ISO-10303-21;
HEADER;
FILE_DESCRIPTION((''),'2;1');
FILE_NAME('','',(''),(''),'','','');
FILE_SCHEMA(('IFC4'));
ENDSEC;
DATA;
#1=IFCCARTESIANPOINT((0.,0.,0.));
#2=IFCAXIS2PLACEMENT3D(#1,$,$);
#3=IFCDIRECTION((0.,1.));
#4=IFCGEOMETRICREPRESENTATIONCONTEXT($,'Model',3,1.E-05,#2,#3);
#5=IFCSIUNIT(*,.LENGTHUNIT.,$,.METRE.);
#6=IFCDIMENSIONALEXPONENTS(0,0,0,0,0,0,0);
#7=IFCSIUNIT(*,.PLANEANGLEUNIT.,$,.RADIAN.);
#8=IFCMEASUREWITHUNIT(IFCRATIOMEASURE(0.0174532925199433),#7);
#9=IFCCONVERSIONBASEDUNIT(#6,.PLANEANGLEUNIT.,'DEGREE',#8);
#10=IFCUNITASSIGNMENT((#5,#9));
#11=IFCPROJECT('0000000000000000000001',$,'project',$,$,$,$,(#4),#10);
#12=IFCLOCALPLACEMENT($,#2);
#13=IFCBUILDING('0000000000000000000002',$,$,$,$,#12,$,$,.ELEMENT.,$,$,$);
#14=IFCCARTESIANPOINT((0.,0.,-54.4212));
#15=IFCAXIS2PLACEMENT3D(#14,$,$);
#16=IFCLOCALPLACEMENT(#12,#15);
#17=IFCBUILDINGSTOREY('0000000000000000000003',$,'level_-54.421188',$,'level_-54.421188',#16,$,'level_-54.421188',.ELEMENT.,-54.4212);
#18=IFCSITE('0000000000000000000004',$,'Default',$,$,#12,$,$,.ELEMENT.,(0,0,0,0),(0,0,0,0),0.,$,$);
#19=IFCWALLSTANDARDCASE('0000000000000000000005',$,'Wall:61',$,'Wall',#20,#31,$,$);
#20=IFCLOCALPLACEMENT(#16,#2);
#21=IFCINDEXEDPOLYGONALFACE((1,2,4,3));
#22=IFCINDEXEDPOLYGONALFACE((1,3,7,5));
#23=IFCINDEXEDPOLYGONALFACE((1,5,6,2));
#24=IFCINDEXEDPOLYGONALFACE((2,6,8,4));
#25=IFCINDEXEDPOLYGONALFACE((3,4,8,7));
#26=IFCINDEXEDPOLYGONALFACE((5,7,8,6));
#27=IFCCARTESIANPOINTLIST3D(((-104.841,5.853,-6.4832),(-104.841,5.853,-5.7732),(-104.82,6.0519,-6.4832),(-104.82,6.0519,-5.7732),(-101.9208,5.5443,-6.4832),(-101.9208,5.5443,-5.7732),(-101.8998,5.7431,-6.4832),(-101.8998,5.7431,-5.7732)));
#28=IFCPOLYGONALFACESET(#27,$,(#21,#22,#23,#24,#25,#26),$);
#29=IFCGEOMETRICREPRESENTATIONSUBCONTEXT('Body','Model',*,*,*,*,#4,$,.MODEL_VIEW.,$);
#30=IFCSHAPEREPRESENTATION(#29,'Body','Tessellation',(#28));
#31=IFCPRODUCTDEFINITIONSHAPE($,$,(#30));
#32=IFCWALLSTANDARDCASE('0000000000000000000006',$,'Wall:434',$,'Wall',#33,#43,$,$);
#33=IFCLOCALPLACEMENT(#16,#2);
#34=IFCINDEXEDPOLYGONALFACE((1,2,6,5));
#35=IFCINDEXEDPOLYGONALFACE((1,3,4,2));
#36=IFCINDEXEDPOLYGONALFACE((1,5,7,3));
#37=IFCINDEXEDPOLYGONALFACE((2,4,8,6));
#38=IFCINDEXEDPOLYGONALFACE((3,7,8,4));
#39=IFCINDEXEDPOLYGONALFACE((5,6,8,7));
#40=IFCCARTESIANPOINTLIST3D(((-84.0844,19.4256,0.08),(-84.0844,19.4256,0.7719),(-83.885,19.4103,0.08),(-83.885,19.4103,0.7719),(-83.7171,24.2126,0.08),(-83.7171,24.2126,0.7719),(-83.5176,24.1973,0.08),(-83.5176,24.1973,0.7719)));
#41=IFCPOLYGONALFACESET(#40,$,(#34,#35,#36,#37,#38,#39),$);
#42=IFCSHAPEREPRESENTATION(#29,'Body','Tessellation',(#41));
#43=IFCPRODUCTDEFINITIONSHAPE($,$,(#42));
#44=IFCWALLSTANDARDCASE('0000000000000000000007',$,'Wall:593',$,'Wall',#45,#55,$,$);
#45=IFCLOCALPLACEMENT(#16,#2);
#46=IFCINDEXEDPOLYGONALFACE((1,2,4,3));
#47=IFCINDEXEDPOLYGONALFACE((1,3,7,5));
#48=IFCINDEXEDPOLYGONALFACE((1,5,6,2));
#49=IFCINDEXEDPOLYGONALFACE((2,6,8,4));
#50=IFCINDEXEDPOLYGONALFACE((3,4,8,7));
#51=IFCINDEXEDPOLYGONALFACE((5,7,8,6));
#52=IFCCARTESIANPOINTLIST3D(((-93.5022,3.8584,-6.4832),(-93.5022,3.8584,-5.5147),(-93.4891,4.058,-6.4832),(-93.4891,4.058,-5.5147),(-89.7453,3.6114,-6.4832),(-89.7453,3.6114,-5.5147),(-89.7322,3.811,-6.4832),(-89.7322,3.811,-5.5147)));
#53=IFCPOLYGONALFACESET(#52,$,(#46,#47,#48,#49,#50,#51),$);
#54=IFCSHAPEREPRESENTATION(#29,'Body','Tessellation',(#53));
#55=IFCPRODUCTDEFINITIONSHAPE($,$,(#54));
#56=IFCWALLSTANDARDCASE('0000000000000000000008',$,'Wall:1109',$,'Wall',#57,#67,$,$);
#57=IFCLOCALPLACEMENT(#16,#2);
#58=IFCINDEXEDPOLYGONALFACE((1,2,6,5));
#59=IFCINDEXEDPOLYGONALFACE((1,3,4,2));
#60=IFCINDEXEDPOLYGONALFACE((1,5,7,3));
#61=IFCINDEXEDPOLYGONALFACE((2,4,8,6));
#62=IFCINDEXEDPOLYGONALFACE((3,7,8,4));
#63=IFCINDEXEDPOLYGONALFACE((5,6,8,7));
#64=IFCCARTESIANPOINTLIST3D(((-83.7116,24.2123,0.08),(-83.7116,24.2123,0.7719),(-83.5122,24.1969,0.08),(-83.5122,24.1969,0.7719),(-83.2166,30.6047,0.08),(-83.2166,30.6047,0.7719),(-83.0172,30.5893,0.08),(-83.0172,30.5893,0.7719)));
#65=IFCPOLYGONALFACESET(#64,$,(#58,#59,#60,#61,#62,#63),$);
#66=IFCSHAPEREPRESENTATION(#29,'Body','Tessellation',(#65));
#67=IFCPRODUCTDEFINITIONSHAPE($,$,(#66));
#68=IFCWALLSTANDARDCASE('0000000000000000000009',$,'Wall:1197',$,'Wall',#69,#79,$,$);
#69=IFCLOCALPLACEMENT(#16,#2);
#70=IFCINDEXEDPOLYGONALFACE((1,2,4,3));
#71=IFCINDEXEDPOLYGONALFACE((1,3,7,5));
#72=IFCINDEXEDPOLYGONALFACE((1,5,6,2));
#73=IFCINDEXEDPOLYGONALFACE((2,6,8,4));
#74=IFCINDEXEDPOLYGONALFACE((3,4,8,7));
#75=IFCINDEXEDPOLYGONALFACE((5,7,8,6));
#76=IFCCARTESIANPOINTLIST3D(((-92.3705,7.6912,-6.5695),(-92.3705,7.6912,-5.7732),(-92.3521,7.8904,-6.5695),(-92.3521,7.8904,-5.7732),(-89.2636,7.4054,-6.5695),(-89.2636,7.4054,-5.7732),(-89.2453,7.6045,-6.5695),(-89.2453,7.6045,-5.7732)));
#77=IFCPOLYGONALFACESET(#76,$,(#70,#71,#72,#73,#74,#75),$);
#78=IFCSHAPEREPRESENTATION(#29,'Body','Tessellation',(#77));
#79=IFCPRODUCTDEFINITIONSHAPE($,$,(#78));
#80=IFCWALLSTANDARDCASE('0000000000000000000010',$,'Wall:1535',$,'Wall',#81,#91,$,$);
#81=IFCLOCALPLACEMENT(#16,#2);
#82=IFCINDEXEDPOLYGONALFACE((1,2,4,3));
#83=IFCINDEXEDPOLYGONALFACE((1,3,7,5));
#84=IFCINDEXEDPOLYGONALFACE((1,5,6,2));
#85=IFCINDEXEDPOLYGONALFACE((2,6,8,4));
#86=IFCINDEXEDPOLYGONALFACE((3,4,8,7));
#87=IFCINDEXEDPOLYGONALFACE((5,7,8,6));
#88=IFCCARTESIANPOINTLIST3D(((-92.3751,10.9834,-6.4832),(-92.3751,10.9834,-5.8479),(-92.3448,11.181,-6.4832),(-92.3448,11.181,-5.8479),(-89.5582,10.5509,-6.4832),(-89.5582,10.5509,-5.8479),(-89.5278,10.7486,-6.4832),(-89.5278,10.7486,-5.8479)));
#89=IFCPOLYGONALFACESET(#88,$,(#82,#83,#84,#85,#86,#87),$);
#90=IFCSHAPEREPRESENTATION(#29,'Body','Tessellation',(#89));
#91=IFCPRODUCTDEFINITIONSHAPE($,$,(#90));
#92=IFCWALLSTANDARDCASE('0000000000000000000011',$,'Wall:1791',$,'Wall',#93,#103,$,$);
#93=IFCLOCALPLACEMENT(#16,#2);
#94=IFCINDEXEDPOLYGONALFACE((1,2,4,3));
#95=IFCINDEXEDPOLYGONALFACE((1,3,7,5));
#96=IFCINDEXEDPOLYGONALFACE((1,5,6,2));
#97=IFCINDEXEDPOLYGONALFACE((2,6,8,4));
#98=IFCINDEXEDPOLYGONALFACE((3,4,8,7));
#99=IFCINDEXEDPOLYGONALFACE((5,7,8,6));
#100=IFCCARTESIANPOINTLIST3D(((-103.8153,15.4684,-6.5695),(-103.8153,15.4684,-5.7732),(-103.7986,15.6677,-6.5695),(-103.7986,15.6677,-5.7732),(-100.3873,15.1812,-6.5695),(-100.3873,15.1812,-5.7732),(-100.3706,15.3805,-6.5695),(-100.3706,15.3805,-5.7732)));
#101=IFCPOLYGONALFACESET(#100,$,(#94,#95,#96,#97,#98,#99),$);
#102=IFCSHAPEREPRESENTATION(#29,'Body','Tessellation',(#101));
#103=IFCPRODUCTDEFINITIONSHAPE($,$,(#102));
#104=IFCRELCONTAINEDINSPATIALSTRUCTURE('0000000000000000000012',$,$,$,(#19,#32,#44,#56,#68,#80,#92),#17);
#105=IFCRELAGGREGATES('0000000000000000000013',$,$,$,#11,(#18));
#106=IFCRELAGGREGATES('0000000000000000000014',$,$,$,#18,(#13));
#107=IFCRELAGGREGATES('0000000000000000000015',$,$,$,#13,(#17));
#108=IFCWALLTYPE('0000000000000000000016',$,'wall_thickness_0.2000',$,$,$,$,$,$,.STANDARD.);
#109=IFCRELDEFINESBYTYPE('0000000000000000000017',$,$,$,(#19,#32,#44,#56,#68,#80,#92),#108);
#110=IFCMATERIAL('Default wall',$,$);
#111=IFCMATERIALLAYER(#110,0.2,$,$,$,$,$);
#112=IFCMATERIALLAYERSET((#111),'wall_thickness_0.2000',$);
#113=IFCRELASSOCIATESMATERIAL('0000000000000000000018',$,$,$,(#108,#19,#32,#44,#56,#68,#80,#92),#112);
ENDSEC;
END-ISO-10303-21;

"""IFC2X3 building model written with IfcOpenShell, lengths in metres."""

from ifc_helpers import new_model, entity, si_unit, converted_unit, direction, frame, origin, place, context, subcontext, project, spatial, polyline, outline, extrude, material, layer, layer_set, layer_usage, type_object, element, save


model = new_model("IFC2X3")

# Units and contexts
model_context = context("Model", 3, precision=1e-05, world=origin(), true_north=direction((0.0, 1.0)))
body_context = subcontext(model_context, "Body", "Model", "MODEL_VIEW")
ifc_project = project(units=[si_unit("LENGTHUNIT", "METRE"), converted_unit("PLANEANGLEUNIT", "DEGREE", entity("IfcRatioMeasure", 0.0174532925199433), si_unit("PLANEANGLEUNIT", "RADIAN"), dimensions=[0, 0, 0, 0, 0, 0, 0])], contexts=[model_context])

# Site, building, storey
placement_1 = place(None, origin())
site = spatial("IfcSite", under=ifc_project, at=placement_1, Name="Default", CompositionType="ELEMENT", RefLatitude=(0, 0, 0, 0), RefLongitude=(0, 0, 0, 0), RefElevation=0.0)
building = spatial("IfcBuilding", under=site, at=placement_1, CompositionType="ELEMENT")
storey_placement = place(placement_1, frame((0.0, 0.0, -54.4212)))
storey = spatial("IfcBuildingStorey", under=building, at=storey_placement, Name="level_-54.421188", ObjectType="level_-54.421188", LongName="level_-54.421188", CompositionType="ELEMENT", Elevation=-54.4212)

# Walls
ifc_material_1 = material(Name="Default wall")
ifc_layer = layer(ifc_material_1, 0.2)
ifc_layer_set = layer_set([ifc_layer], Name="wall_thickness_0.2000")
ifc_layer_usage = layer_usage(ifc_layer_set, "AXIS2", "POSITIVE", -0.1)
wall_type = type_object("IfcWallType", Name="wall_thickness_0.2000", PredefinedType="STANDARD", material=ifc_layer_set)
placement_2 = place(placement_1, frame((0.0, 0.0, -60.9044)))
wall_1_placement = place(placement_2, frame((-104.8305, 5.9525, 0.0), z_axis=(0.0, 0.0, 1.0), x_axis=(0.994456, -0.105154, 0.0)))
element("IfcWallStandardCase", 1, at=wall_1_placement, inside=storey, type_object=wall_type, material=ifc_layer_usage, Name="Wall:61", ObjectType="Wall", context=body_context, shape_type="SweptSolid", body=[
    extrude(outline(polyline([(2.9364, -0.1), (2.9364, 0.1), (0.0, 0.1), (0.0, -0.1), (2.9364, -0.1)])), origin(), (0.0, 0.0, 1.0), 0.7101),
])
placement_3 = place(placement_1, frame((0.0, 0.0, -54.3412)))
wall_2_placement = place(placement_3, frame((-83.9847, 19.4179, 0.0), z_axis=(0.0, 0.0, 1.0), x_axis=(0.07652, 0.997068, 0.0)))
element("IfcWallStandardCase", 2, at=wall_2_placement, inside=storey, type_object=wall_type, material=ifc_layer_usage, Name="Wall:434", ObjectType="Wall", context=body_context, shape_type="SweptSolid", body=[
    extrude(outline(polyline([(4.8011, -0.1), (4.8011, 0.1), (0.0, 0.1), (0.0, -0.1), (4.8011, -0.1)])), origin(), (0.0, 0.0, 1.0), 0.692),
])
placement_4 = place(placement_1, frame((0.0, 0.0, -60.9044)))
wall_3_placement = place(placement_4, frame((-93.4956, 3.9582, 0.0), z_axis=(0.0, 0.0, 1.0), x_axis=(0.997845, -0.065615, 0.0)))
element("IfcWallStandardCase", 3, at=wall_3_placement, inside=storey, type_object=wall_type, material=ifc_layer_usage, Name="Wall:593", ObjectType="Wall", context=body_context, shape_type="SweptSolid", body=[
    extrude(outline(polyline([(3.765, -0.1), (3.765, 0.1), (0.0, 0.1), (0.0, -0.1), (3.765, -0.1)])), origin(), (0.0, 0.0, 1.0), 0.9686),
])
placement_5 = place(placement_1, frame((0.0, 0.0, -54.3412)))
wall_4_placement = place(placement_5, frame((-83.6119, 24.2046, 0.0), z_axis=(0.0, 0.0, 1.0), x_axis=(0.077207, 0.997015, 0.0)))
element("IfcWallStandardCase", 4, at=wall_4_placement, inside=storey, type_object=wall_type, material=ifc_layer_usage, Name="Wall:1109", ObjectType="Wall", context=body_context, shape_type="SweptSolid", body=[
    extrude(outline(polyline([(6.4116, -0.1), (6.4116, 0.1), (0.0, 0.1), (0.0, -0.1), (6.4116, -0.1)])), origin(), (0.0, 0.0, 1.0), 0.692),
])
placement_6 = place(placement_1, frame((0.0, 0.0, -60.9907)))
wall_5_placement = place(placement_6, frame((-92.3613, 7.7908, 0.0), z_axis=(0.0, 0.0, 1.0), x_axis=(0.995794, -0.091616, 0.0)))
element("IfcWallStandardCase", 5, at=wall_5_placement, inside=storey, type_object=wall_type, material=ifc_layer_usage, Name="Wall:1197", ObjectType="Wall", context=body_context, shape_type="SweptSolid", body=[
    extrude(outline(polyline([(3.12, -0.1), (3.12, 0.1), (0.0, 0.1), (0.0, -0.1), (3.12, -0.1)])), origin(), (0.0, 0.0, 1.0), 0.7963),
])
placement_7 = place(placement_1, frame((0.0, 0.0, -60.9044)))
wall_6_placement = place(placement_7, frame((-92.36, 11.0822, 0.0), z_axis=(0.0, 0.0, 1.0), x_axis=(0.988419, -0.151747, 0.0)))
element("IfcWallStandardCase", 6, at=wall_6_placement, inside=storey, type_object=wall_type, material=ifc_layer_usage, Name="Wall:1535", ObjectType="Wall", context=body_context, shape_type="SweptSolid", body=[
    extrude(outline(polyline([(2.85, -0.1), (2.85, 0.1), (0.0, 0.1), (0.0, -0.1), (2.85, -0.1)])), origin(), (0.0, 0.0, 1.0), 0.6353),
])
placement_8 = place(placement_1, frame((0.0, 0.0, -60.9907)))
wall_7_placement = place(placement_8, frame((-103.8069, 15.5681, 0.0), z_axis=(0.0, 0.0, 1.0), x_axis=(0.996508, -0.083492, 0.0)))
element("IfcWallStandardCase", 7, at=wall_7_placement, inside=storey, type_object=wall_type, material=ifc_layer_usage, Name="Wall:1791", ObjectType="Wall", context=body_context, shape_type="SweptSolid", body=[
    extrude(outline(polyline([(3.44, -0.1), (3.44, 0.1), (0.0, 0.1), (0.0, -0.1), (3.44, -0.1)])), origin(), (0.0, 0.0, 1.0), 0.7963),
])

save(model, "model.ifc")
